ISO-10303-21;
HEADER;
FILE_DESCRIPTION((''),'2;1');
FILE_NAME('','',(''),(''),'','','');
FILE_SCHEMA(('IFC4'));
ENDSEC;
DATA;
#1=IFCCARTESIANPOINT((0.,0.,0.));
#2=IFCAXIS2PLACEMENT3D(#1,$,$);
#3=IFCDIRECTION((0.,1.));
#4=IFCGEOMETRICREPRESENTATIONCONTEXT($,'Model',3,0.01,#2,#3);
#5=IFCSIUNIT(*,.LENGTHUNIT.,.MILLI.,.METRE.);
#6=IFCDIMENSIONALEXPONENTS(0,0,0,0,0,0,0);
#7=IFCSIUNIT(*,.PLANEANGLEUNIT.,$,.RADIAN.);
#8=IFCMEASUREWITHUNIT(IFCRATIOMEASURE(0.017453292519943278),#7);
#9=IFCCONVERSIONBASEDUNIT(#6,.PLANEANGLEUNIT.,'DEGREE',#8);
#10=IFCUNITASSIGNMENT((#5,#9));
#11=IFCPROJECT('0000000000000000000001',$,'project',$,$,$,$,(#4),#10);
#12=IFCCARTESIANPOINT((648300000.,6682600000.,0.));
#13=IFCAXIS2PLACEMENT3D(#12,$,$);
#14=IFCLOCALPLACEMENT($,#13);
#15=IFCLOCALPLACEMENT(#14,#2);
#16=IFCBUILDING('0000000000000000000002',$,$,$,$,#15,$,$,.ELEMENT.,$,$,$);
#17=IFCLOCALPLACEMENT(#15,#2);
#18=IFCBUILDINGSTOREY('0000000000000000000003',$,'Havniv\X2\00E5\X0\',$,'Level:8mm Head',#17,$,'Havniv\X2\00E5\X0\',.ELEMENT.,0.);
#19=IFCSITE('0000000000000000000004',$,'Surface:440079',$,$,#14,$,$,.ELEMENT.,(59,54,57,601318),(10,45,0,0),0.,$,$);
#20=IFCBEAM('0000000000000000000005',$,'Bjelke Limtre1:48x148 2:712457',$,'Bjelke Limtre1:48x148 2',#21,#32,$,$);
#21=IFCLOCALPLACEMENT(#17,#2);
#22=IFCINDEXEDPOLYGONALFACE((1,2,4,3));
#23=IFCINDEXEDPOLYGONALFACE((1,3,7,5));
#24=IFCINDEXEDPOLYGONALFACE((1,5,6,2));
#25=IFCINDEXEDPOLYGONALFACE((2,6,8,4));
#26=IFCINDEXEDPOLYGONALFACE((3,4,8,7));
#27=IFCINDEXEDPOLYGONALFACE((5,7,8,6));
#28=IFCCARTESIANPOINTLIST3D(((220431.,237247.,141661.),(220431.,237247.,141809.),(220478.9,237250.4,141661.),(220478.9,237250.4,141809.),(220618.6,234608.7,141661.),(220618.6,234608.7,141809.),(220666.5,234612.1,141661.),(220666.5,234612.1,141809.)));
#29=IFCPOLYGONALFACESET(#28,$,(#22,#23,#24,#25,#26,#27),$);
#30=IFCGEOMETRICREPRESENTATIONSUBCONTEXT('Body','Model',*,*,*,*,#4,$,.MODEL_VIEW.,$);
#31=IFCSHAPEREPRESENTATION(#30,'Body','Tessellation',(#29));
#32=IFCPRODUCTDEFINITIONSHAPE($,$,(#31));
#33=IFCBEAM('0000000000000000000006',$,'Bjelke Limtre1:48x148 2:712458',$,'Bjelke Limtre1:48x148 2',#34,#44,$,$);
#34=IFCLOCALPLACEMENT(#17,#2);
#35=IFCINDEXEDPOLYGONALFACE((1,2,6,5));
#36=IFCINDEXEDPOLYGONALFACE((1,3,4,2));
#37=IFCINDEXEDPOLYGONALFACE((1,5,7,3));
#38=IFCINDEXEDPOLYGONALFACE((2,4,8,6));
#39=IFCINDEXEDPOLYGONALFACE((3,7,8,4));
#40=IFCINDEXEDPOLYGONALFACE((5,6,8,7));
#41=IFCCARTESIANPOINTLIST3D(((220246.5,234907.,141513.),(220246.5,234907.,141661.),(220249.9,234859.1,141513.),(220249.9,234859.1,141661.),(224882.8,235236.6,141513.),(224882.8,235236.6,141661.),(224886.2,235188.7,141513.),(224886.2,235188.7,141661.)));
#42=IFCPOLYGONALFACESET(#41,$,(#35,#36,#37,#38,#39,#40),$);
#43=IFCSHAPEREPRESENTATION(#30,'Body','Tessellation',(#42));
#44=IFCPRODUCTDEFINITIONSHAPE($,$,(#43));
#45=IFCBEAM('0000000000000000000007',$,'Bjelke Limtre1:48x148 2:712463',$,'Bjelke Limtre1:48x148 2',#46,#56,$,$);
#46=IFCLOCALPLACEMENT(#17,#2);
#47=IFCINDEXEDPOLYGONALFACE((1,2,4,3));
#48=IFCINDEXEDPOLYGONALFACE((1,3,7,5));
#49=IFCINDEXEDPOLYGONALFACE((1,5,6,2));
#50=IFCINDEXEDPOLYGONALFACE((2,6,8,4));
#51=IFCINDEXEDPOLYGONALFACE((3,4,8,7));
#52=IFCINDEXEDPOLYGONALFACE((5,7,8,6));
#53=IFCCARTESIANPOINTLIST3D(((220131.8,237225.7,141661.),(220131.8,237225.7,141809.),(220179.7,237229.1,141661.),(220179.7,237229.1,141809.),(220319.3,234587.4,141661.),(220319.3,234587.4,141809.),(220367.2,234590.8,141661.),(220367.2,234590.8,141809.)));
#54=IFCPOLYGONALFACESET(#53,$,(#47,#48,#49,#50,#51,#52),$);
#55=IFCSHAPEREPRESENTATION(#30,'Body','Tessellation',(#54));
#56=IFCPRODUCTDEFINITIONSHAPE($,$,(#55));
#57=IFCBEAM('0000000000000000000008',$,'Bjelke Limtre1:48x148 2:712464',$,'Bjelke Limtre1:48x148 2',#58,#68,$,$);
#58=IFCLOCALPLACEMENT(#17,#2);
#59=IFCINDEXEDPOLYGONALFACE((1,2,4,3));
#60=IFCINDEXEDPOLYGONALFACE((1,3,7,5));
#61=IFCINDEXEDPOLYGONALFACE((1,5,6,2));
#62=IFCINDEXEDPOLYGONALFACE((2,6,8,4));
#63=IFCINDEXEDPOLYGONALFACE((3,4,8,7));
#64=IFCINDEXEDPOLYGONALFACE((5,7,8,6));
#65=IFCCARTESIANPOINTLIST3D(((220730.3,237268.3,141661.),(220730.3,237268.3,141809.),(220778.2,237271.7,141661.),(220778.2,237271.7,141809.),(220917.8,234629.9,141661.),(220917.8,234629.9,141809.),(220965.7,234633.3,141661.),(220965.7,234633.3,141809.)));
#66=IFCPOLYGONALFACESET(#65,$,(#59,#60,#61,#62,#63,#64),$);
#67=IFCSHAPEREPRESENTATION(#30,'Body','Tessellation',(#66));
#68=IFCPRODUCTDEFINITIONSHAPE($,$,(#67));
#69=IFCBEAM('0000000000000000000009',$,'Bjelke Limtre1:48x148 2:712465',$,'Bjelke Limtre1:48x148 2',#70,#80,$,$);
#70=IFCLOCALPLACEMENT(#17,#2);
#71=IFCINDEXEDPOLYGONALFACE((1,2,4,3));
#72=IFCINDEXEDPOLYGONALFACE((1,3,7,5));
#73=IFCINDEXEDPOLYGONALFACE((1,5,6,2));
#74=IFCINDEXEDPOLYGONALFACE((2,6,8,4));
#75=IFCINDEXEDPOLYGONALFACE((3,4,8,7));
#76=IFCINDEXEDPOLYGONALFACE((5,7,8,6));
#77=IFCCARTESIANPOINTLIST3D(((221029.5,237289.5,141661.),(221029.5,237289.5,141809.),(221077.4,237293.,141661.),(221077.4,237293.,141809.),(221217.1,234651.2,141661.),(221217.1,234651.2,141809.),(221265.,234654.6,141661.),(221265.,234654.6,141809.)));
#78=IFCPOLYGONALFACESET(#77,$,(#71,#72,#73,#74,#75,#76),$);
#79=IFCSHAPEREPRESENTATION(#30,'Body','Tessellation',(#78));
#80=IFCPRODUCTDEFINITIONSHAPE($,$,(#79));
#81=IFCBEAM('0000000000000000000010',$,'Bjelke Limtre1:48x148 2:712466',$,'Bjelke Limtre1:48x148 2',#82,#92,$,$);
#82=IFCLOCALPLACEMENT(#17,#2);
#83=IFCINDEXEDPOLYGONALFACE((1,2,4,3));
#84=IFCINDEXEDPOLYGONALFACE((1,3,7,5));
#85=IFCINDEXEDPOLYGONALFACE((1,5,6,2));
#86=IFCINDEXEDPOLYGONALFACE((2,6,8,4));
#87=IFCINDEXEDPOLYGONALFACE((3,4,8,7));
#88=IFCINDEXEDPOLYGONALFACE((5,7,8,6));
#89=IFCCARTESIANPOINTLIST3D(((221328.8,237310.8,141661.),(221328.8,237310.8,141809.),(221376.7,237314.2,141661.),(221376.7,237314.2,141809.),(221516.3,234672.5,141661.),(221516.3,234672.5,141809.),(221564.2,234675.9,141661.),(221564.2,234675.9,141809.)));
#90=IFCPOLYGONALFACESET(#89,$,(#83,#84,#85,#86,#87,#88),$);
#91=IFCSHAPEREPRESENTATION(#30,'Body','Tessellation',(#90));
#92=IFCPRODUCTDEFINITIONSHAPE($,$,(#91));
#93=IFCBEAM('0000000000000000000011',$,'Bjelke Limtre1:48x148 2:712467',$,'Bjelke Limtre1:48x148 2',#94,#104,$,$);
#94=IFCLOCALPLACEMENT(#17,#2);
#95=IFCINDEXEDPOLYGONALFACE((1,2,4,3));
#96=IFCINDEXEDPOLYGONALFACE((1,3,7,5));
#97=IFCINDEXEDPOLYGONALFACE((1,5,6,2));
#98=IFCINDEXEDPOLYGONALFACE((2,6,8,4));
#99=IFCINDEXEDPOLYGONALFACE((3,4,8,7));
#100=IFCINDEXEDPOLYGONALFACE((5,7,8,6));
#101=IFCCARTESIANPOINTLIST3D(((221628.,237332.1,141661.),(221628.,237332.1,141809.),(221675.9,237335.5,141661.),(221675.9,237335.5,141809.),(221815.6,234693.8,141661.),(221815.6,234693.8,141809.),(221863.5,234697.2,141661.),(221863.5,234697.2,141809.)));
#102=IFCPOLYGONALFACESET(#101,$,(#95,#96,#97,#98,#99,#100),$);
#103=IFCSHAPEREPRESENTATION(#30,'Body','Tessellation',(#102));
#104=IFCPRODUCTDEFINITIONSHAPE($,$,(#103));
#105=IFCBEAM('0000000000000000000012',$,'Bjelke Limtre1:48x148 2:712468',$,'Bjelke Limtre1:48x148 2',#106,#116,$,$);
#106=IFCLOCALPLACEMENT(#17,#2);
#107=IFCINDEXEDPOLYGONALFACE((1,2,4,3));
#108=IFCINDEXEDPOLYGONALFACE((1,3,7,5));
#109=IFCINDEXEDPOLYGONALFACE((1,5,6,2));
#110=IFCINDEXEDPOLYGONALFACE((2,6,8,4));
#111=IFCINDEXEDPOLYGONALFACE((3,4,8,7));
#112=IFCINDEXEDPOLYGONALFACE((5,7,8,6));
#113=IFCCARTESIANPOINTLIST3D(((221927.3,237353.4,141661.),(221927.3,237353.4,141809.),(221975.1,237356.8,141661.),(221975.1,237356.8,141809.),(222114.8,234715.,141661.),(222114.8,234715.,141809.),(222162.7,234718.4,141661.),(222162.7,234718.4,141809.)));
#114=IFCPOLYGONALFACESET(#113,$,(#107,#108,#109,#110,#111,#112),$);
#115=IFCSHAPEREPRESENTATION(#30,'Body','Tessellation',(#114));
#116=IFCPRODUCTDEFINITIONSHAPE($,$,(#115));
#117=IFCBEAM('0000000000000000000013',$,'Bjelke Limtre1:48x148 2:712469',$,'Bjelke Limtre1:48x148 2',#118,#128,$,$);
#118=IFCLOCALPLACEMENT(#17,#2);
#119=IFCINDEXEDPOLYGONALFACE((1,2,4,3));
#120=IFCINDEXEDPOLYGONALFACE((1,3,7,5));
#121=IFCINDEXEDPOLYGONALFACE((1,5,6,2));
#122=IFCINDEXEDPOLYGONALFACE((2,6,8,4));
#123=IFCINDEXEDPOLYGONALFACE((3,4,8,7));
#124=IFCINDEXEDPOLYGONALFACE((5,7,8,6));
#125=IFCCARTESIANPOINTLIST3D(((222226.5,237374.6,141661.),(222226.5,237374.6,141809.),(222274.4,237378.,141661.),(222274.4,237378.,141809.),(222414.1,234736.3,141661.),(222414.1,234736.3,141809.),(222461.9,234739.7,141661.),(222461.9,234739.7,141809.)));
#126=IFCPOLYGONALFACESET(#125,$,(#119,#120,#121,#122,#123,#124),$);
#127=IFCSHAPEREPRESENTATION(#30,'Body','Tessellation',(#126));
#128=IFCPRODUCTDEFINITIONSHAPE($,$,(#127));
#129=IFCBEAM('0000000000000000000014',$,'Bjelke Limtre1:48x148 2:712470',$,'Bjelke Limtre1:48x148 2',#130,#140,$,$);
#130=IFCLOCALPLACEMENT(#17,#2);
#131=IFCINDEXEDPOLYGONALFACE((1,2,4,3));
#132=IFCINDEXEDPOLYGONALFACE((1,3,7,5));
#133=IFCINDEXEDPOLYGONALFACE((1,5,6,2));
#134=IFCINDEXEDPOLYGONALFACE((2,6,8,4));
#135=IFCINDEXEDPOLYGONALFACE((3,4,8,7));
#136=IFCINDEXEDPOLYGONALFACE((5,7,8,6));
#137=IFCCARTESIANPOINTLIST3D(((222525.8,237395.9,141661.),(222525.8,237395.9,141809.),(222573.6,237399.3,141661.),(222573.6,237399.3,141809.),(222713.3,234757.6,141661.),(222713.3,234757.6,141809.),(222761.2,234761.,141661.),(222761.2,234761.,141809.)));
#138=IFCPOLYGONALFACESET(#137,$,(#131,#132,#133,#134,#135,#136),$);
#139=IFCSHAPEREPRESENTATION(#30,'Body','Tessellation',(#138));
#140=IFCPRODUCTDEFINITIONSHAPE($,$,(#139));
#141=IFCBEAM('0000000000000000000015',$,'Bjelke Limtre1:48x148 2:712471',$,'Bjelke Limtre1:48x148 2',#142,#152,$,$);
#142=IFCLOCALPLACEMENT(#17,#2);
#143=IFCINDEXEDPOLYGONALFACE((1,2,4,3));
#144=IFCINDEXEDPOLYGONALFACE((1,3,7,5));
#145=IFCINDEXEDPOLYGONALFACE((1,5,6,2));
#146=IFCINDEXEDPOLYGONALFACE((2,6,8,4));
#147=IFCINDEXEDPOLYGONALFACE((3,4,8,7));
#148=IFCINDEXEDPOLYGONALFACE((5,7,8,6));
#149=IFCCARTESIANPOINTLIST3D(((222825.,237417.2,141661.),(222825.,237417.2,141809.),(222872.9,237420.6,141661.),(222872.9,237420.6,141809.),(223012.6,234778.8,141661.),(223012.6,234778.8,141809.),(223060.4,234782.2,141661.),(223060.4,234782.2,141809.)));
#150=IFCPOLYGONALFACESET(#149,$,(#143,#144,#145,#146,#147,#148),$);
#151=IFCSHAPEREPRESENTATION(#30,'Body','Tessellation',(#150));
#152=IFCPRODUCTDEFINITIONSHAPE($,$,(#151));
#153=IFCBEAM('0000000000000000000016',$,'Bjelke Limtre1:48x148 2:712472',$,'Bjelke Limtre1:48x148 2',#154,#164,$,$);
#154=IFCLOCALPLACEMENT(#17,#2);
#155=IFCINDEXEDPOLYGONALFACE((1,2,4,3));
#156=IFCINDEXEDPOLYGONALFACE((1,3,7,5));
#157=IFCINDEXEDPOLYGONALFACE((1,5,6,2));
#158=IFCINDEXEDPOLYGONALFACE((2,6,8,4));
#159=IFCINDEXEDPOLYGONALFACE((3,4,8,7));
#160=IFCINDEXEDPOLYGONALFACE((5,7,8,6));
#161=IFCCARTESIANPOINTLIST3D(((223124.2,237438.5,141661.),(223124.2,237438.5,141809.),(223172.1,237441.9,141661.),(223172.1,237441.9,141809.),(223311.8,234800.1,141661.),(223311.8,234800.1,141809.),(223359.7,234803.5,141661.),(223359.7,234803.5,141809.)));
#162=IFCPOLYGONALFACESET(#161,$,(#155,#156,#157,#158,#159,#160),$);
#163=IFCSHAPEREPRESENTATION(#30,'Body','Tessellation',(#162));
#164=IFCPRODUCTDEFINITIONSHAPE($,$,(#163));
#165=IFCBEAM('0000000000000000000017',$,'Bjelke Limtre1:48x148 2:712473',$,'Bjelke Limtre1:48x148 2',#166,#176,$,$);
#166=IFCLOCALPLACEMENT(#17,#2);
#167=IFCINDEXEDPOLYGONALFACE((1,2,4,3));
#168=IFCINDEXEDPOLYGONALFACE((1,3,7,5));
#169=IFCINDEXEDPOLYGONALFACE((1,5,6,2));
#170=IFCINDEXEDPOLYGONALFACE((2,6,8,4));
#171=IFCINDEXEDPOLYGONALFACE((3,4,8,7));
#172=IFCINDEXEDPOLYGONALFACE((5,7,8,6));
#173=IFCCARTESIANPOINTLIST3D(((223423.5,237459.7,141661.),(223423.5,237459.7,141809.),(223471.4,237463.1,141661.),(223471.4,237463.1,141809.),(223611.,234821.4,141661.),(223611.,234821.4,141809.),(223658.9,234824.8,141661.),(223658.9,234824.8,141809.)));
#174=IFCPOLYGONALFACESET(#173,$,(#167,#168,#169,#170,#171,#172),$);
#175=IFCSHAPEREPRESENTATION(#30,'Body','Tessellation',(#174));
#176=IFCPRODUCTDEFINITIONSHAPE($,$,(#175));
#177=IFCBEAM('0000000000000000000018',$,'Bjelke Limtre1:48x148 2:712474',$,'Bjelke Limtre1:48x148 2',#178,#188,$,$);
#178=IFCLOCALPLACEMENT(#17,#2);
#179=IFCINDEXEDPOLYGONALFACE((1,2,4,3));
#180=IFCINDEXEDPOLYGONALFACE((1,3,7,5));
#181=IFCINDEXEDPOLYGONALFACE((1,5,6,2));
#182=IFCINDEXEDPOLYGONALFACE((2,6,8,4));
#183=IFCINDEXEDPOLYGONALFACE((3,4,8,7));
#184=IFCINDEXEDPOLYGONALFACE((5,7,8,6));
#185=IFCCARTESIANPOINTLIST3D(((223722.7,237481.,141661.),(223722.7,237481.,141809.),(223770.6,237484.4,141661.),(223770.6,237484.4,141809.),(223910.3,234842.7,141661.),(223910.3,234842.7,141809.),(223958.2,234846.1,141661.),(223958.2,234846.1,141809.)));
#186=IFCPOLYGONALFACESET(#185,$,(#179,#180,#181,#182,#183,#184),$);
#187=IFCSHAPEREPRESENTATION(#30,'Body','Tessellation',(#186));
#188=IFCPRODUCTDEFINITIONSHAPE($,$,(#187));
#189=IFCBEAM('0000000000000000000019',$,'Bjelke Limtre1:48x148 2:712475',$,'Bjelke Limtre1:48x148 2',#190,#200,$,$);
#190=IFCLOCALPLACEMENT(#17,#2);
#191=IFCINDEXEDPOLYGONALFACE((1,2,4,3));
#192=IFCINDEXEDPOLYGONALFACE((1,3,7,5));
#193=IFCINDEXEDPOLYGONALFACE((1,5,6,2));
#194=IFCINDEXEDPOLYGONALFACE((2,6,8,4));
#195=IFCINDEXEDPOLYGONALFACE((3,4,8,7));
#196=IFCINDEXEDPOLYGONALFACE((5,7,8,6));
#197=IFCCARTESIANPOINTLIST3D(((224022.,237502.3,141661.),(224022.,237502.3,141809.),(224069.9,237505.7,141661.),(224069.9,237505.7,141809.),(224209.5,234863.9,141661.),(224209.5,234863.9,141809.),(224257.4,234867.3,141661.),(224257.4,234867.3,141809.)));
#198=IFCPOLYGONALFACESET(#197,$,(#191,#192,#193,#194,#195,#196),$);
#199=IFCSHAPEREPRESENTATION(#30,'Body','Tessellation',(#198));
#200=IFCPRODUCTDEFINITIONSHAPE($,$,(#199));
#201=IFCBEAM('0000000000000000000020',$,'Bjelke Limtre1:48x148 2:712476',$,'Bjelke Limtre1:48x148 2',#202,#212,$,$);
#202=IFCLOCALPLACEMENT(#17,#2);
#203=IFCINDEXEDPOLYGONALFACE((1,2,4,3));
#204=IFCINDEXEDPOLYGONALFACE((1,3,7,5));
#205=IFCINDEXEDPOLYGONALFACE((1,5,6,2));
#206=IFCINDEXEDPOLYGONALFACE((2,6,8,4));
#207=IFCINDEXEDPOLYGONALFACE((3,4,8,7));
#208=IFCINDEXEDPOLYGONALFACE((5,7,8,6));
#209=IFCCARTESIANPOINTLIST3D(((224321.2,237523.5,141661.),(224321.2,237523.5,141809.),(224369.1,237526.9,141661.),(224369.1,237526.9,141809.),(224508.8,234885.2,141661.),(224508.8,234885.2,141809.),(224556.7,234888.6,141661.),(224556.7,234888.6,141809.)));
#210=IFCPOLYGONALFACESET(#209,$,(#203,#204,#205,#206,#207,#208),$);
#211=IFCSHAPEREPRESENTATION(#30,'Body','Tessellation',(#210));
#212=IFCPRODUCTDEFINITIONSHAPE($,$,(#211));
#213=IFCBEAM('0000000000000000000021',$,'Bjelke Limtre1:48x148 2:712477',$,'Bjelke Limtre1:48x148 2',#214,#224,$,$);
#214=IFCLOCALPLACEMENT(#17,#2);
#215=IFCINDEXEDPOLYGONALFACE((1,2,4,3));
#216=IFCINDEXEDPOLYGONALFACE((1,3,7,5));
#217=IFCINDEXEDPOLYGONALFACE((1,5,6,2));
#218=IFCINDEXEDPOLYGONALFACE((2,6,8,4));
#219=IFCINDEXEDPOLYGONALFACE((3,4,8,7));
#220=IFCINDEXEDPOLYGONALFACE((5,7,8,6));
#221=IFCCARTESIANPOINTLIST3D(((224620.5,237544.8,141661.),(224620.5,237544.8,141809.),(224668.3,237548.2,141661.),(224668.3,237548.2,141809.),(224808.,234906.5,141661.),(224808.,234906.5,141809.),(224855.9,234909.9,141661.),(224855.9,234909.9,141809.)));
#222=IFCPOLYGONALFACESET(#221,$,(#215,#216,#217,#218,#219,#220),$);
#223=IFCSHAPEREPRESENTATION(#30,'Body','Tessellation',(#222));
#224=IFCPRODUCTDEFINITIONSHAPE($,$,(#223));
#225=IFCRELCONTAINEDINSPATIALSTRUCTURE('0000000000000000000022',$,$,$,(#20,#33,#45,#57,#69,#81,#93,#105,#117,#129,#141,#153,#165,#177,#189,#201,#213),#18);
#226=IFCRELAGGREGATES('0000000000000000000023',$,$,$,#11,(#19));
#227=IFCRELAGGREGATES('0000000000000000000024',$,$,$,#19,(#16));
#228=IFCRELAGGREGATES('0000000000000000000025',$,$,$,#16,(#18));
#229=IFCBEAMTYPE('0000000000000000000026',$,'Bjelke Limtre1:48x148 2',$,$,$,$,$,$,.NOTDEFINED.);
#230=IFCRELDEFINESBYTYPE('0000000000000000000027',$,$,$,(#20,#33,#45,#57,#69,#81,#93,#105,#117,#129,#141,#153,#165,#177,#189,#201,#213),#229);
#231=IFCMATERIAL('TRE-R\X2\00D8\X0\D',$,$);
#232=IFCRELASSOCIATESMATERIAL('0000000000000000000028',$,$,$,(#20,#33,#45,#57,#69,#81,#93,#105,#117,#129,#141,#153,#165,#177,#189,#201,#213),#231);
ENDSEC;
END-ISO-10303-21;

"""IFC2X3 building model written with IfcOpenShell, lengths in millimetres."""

from ifc_helpers import new_model, entity, si_unit, converted_unit, direction, frame, frame_2d, origin, origin_2d_with_axis, place, context, subcontext, project, spatial, rectangle, extrude, material, type_object, element, save


model = new_model("IFC2X3")

# Units and contexts
model_context = context("Model", 3, precision=0.01, world=origin(), true_north=direction((0.0, 1.0)))
body_context = subcontext(model_context, "Body", "Model", "MODEL_VIEW")
ifc_project = project(units=[si_unit("LENGTHUNIT", "METRE", prefix="MILLI"), converted_unit("PLANEANGLEUNIT", "DEGREE", entity("IfcRatioMeasure", 0.017453292519943278), si_unit("PLANEANGLEUNIT", "RADIAN"), dimensions=[0, 0, 0, 0, 0, 0, 0])], contexts=[model_context])

# Site, building, storey
site_placement = place(None, frame((648300000.0, 6682600000.0, 0.0)))
site = spatial("IfcSite", under=ifc_project, at=site_placement, Name="Surface:440079", CompositionType="ELEMENT", RefLatitude=(59, 54, 57, 601318), RefLongitude=(10, 45, 0, 0), RefElevation=0.0)
building_placement = place(site_placement, origin())
building = spatial("IfcBuilding", under=site, at=building_placement, CompositionType="ELEMENT")
storey_placement = place(building_placement, origin())
storey = spatial("IfcBuildingStorey", under=building, at=storey_placement, Name="Havnivå", ObjectType="Level:8mm Head", LongName="Havnivå", CompositionType="ELEMENT", Elevation=0.0)

# Beams
ifc_material_1 = material(Name="TRE-RØD")
beam_type = type_object("IfcBeamType", Name="Bjelke Limtre1:48x148 2", PredefinedType="NOTDEFINED")
for number, where, z_axis, x_axis, name in (
    (1, (220455.0, 237248.7, 141809.0), (0.0, 0.0, 1.0), (0.070908, -0.997483, 0.0), "Bjelke Limtre1:48x148 2:712457"),
):
    element("IfcBeam", number, at=place(storey_placement, frame(where, z_axis=z_axis, x_axis=x_axis)), inside=storey, type_object=beam_type, material=ifc_material_1, Name=name, ObjectType="Bjelke Limtre1:48x148 2", context=body_context, shape_type="SweptSolid", body=[
        extrude(rectangle(XDim=148.0, YDim=48.0, at=frame_2d((0.0, 0.0), x_axis=(1.0, 0.0))), frame((0.0, 0.0, -74.0), z_axis=(1.0, 0.0, 0.0), x_axis=(0.0, 0.0, -1.0)), (0.0, 0.0, 1.0), 2645.0),
    ])
beam_1_placement = place(storey_placement, frame((220248.2, 234883.1, 141661.0), z_axis=(0.0, 0.0, 1.0), x_axis=(0.997483, 0.070908, 0.0)))
element("IfcBeam", 2, at=beam_1_placement, inside=storey, type_object=beam_type, material=ifc_material_1, Name="Bjelke Limtre1:48x148 2:712458", ObjectType="Bjelke Limtre1:48x148 2", context=body_context, shape_type="SweptSolid", body=[
    extrude(rectangle(XDim=148.0, YDim=48.0, at=frame_2d((0.0, 0.0), x_axis=(1.0, 0.0))), frame((0.0, 0.0, -74.0), z_axis=(1.0, 0.0, 0.0), x_axis=(0.0, 0.0, -1.0)), (0.0, 0.0, 1.0), 4648.0),
])
beam_2_placement = place(storey_placement, frame((220155.7, 237227.4, 141809.0), z_axis=(0.0, 0.0, 1.0), x_axis=(0.070908, -0.997483, 0.0)))
element("IfcBeam", 3, at=beam_2_placement, inside=storey, type_object=beam_type, material=ifc_material_1, Name="Bjelke Limtre1:48x148 2:712463", ObjectType="Bjelke Limtre1:48x148 2", context=body_context, shape_type="SweptSolid", body=[
    extrude(rectangle(XDim=148.0, YDim=48.0, at=frame_2d((0.0, 0.0), x_axis=(1.0, 0.0))), frame((0.0, 0.0, -74.0), z_axis=(1.0, 0.0, 0.0), x_axis=(0.0, 0.0, -1.0)), (0.0, 0.0, 1.0), 2645.0),
])
for number, where, z_axis, x_axis, name in (
    (4, (220754.2, 237270.0, 141809.0), (0.0, 0.0, 1.0), (0.070908, -0.997483, 0.0), "Bjelke Limtre1:48x148 2:712464"),
    (5, (221053.5, 237291.3, 141809.0), (0.0, 0.0, 1.0), (0.070908, -0.997483, 0.0), "Bjelke Limtre1:48x148 2:712465"),
    (6, (221352.7, 237312.5, 141809.0), (0.0, 0.0, 1.0), (0.070908, -0.997483, 0.0), "Bjelke Limtre1:48x148 2:712466"),
    (7, (221652.0, 237333.8, 141809.0), (0.0, 0.0, 1.0), (0.070908, -0.997483, 0.0), "Bjelke Limtre1:48x148 2:712467"),
    (8, (221951.2, 237355.1, 141809.0), (0.0, 0.0, 1.0), (0.070908, -0.997483, 0.0), "Bjelke Limtre1:48x148 2:712468"),
    (9, (222250.5, 237376.3, 141809.0), (0.0, 0.0, 1.0), (0.070908, -0.997483, 0.0), "Bjelke Limtre1:48x148 2:712469"),
    (10, (222549.7, 237397.6, 141809.0), (0.0, 0.0, 1.0), (0.070908, -0.997483, 0.0), "Bjelke Limtre1:48x148 2:712470"),
    (11, (222848.9, 237418.9, 141809.0), (0.0, 0.0, 1.0), (0.070908, -0.997483, 0.0), "Bjelke Limtre1:48x148 2:712471"),
):
    element("IfcBeam", number, at=place(storey_placement, frame(where, z_axis=z_axis, x_axis=x_axis)), inside=storey, type_object=beam_type, material=ifc_material_1, Name=name, ObjectType="Bjelke Limtre1:48x148 2", context=body_context, shape_type="SweptSolid", body=[
        extrude(rectangle(XDim=148.0, YDim=48.0, at=origin_2d_with_axis()), frame((0.0, 0.0, -74.0), z_axis=(1.0, 0.0, 0.0), x_axis=(0.0, 0.0, -1.0)), (0.0, 0.0, 1.0), 2645.0),
    ])
for number, where, z_axis, x_axis, name in (
    (12, (223148.2, 237440.2, 141809.0), (0.0, 0.0, 1.0), (0.070908, -0.997483, 0.0), "Bjelke Limtre1:48x148 2:712472"),
    (13, (223447.4, 237461.4, 141809.0), (0.0, 0.0, 1.0), (0.070908, -0.997483, 0.0), "Bjelke Limtre1:48x148 2:712473"),
):
    element("IfcBeam", number, at=place(storey_placement, frame(where, z_axis=z_axis, x_axis=x_axis)), inside=storey, type_object=beam_type, material=ifc_material_1, Name=name, ObjectType="Bjelke Limtre1:48x148 2", context=body_context, shape_type="SweptSolid", body=[
        extrude(rectangle(XDim=148.0, YDim=48.0, at=frame_2d((0.0, 0.0), x_axis=(1.0, 0.0))), frame((0.0, 0.0, -74.0), z_axis=(1.0, 0.0, 0.0), x_axis=(0.0, 0.0, -1.0)), (0.0, 0.0, 1.0), 2645.0),
    ])
for number, where, z_axis, x_axis, name in (
    (14, (223746.7, 237482.7, 141809.0), (0.0, 0.0, 1.0), (0.070908, -0.997483, 0.0), "Bjelke Limtre1:48x148 2:712474"),
    (15, (224045.9, 237504.0, 141809.0), (0.0, 0.0, 1.0), (0.070908, -0.997483, 0.0), "Bjelke Limtre1:48x148 2:712475"),
    (16, (224345.2, 237525.2, 141809.0), (0.0, 0.0, 1.0), (0.070908, -0.997483, 0.0), "Bjelke Limtre1:48x148 2:712476"),
    (17, (224644.4, 237546.5, 141809.0), (0.0, 0.0, 1.0), (0.070908, -0.997483, 0.0), "Bjelke Limtre1:48x148 2:712477"),
):
    element("IfcBeam", number, at=place(storey_placement, frame(where, z_axis=z_axis, x_axis=x_axis)), inside=storey, type_object=beam_type, material=ifc_material_1, Name=name, ObjectType="Bjelke Limtre1:48x148 2", context=body_context, shape_type="SweptSolid", body=[
        extrude(rectangle(XDim=148.0, YDim=48.0, at=origin_2d_with_axis()), frame((0.0, 0.0, -74.0), z_axis=(1.0, 0.0, 0.0), x_axis=(0.0, 0.0, -1.0)), (0.0, 0.0, 1.0), 2645.0),
    ])

save(model, "model.ifc")
